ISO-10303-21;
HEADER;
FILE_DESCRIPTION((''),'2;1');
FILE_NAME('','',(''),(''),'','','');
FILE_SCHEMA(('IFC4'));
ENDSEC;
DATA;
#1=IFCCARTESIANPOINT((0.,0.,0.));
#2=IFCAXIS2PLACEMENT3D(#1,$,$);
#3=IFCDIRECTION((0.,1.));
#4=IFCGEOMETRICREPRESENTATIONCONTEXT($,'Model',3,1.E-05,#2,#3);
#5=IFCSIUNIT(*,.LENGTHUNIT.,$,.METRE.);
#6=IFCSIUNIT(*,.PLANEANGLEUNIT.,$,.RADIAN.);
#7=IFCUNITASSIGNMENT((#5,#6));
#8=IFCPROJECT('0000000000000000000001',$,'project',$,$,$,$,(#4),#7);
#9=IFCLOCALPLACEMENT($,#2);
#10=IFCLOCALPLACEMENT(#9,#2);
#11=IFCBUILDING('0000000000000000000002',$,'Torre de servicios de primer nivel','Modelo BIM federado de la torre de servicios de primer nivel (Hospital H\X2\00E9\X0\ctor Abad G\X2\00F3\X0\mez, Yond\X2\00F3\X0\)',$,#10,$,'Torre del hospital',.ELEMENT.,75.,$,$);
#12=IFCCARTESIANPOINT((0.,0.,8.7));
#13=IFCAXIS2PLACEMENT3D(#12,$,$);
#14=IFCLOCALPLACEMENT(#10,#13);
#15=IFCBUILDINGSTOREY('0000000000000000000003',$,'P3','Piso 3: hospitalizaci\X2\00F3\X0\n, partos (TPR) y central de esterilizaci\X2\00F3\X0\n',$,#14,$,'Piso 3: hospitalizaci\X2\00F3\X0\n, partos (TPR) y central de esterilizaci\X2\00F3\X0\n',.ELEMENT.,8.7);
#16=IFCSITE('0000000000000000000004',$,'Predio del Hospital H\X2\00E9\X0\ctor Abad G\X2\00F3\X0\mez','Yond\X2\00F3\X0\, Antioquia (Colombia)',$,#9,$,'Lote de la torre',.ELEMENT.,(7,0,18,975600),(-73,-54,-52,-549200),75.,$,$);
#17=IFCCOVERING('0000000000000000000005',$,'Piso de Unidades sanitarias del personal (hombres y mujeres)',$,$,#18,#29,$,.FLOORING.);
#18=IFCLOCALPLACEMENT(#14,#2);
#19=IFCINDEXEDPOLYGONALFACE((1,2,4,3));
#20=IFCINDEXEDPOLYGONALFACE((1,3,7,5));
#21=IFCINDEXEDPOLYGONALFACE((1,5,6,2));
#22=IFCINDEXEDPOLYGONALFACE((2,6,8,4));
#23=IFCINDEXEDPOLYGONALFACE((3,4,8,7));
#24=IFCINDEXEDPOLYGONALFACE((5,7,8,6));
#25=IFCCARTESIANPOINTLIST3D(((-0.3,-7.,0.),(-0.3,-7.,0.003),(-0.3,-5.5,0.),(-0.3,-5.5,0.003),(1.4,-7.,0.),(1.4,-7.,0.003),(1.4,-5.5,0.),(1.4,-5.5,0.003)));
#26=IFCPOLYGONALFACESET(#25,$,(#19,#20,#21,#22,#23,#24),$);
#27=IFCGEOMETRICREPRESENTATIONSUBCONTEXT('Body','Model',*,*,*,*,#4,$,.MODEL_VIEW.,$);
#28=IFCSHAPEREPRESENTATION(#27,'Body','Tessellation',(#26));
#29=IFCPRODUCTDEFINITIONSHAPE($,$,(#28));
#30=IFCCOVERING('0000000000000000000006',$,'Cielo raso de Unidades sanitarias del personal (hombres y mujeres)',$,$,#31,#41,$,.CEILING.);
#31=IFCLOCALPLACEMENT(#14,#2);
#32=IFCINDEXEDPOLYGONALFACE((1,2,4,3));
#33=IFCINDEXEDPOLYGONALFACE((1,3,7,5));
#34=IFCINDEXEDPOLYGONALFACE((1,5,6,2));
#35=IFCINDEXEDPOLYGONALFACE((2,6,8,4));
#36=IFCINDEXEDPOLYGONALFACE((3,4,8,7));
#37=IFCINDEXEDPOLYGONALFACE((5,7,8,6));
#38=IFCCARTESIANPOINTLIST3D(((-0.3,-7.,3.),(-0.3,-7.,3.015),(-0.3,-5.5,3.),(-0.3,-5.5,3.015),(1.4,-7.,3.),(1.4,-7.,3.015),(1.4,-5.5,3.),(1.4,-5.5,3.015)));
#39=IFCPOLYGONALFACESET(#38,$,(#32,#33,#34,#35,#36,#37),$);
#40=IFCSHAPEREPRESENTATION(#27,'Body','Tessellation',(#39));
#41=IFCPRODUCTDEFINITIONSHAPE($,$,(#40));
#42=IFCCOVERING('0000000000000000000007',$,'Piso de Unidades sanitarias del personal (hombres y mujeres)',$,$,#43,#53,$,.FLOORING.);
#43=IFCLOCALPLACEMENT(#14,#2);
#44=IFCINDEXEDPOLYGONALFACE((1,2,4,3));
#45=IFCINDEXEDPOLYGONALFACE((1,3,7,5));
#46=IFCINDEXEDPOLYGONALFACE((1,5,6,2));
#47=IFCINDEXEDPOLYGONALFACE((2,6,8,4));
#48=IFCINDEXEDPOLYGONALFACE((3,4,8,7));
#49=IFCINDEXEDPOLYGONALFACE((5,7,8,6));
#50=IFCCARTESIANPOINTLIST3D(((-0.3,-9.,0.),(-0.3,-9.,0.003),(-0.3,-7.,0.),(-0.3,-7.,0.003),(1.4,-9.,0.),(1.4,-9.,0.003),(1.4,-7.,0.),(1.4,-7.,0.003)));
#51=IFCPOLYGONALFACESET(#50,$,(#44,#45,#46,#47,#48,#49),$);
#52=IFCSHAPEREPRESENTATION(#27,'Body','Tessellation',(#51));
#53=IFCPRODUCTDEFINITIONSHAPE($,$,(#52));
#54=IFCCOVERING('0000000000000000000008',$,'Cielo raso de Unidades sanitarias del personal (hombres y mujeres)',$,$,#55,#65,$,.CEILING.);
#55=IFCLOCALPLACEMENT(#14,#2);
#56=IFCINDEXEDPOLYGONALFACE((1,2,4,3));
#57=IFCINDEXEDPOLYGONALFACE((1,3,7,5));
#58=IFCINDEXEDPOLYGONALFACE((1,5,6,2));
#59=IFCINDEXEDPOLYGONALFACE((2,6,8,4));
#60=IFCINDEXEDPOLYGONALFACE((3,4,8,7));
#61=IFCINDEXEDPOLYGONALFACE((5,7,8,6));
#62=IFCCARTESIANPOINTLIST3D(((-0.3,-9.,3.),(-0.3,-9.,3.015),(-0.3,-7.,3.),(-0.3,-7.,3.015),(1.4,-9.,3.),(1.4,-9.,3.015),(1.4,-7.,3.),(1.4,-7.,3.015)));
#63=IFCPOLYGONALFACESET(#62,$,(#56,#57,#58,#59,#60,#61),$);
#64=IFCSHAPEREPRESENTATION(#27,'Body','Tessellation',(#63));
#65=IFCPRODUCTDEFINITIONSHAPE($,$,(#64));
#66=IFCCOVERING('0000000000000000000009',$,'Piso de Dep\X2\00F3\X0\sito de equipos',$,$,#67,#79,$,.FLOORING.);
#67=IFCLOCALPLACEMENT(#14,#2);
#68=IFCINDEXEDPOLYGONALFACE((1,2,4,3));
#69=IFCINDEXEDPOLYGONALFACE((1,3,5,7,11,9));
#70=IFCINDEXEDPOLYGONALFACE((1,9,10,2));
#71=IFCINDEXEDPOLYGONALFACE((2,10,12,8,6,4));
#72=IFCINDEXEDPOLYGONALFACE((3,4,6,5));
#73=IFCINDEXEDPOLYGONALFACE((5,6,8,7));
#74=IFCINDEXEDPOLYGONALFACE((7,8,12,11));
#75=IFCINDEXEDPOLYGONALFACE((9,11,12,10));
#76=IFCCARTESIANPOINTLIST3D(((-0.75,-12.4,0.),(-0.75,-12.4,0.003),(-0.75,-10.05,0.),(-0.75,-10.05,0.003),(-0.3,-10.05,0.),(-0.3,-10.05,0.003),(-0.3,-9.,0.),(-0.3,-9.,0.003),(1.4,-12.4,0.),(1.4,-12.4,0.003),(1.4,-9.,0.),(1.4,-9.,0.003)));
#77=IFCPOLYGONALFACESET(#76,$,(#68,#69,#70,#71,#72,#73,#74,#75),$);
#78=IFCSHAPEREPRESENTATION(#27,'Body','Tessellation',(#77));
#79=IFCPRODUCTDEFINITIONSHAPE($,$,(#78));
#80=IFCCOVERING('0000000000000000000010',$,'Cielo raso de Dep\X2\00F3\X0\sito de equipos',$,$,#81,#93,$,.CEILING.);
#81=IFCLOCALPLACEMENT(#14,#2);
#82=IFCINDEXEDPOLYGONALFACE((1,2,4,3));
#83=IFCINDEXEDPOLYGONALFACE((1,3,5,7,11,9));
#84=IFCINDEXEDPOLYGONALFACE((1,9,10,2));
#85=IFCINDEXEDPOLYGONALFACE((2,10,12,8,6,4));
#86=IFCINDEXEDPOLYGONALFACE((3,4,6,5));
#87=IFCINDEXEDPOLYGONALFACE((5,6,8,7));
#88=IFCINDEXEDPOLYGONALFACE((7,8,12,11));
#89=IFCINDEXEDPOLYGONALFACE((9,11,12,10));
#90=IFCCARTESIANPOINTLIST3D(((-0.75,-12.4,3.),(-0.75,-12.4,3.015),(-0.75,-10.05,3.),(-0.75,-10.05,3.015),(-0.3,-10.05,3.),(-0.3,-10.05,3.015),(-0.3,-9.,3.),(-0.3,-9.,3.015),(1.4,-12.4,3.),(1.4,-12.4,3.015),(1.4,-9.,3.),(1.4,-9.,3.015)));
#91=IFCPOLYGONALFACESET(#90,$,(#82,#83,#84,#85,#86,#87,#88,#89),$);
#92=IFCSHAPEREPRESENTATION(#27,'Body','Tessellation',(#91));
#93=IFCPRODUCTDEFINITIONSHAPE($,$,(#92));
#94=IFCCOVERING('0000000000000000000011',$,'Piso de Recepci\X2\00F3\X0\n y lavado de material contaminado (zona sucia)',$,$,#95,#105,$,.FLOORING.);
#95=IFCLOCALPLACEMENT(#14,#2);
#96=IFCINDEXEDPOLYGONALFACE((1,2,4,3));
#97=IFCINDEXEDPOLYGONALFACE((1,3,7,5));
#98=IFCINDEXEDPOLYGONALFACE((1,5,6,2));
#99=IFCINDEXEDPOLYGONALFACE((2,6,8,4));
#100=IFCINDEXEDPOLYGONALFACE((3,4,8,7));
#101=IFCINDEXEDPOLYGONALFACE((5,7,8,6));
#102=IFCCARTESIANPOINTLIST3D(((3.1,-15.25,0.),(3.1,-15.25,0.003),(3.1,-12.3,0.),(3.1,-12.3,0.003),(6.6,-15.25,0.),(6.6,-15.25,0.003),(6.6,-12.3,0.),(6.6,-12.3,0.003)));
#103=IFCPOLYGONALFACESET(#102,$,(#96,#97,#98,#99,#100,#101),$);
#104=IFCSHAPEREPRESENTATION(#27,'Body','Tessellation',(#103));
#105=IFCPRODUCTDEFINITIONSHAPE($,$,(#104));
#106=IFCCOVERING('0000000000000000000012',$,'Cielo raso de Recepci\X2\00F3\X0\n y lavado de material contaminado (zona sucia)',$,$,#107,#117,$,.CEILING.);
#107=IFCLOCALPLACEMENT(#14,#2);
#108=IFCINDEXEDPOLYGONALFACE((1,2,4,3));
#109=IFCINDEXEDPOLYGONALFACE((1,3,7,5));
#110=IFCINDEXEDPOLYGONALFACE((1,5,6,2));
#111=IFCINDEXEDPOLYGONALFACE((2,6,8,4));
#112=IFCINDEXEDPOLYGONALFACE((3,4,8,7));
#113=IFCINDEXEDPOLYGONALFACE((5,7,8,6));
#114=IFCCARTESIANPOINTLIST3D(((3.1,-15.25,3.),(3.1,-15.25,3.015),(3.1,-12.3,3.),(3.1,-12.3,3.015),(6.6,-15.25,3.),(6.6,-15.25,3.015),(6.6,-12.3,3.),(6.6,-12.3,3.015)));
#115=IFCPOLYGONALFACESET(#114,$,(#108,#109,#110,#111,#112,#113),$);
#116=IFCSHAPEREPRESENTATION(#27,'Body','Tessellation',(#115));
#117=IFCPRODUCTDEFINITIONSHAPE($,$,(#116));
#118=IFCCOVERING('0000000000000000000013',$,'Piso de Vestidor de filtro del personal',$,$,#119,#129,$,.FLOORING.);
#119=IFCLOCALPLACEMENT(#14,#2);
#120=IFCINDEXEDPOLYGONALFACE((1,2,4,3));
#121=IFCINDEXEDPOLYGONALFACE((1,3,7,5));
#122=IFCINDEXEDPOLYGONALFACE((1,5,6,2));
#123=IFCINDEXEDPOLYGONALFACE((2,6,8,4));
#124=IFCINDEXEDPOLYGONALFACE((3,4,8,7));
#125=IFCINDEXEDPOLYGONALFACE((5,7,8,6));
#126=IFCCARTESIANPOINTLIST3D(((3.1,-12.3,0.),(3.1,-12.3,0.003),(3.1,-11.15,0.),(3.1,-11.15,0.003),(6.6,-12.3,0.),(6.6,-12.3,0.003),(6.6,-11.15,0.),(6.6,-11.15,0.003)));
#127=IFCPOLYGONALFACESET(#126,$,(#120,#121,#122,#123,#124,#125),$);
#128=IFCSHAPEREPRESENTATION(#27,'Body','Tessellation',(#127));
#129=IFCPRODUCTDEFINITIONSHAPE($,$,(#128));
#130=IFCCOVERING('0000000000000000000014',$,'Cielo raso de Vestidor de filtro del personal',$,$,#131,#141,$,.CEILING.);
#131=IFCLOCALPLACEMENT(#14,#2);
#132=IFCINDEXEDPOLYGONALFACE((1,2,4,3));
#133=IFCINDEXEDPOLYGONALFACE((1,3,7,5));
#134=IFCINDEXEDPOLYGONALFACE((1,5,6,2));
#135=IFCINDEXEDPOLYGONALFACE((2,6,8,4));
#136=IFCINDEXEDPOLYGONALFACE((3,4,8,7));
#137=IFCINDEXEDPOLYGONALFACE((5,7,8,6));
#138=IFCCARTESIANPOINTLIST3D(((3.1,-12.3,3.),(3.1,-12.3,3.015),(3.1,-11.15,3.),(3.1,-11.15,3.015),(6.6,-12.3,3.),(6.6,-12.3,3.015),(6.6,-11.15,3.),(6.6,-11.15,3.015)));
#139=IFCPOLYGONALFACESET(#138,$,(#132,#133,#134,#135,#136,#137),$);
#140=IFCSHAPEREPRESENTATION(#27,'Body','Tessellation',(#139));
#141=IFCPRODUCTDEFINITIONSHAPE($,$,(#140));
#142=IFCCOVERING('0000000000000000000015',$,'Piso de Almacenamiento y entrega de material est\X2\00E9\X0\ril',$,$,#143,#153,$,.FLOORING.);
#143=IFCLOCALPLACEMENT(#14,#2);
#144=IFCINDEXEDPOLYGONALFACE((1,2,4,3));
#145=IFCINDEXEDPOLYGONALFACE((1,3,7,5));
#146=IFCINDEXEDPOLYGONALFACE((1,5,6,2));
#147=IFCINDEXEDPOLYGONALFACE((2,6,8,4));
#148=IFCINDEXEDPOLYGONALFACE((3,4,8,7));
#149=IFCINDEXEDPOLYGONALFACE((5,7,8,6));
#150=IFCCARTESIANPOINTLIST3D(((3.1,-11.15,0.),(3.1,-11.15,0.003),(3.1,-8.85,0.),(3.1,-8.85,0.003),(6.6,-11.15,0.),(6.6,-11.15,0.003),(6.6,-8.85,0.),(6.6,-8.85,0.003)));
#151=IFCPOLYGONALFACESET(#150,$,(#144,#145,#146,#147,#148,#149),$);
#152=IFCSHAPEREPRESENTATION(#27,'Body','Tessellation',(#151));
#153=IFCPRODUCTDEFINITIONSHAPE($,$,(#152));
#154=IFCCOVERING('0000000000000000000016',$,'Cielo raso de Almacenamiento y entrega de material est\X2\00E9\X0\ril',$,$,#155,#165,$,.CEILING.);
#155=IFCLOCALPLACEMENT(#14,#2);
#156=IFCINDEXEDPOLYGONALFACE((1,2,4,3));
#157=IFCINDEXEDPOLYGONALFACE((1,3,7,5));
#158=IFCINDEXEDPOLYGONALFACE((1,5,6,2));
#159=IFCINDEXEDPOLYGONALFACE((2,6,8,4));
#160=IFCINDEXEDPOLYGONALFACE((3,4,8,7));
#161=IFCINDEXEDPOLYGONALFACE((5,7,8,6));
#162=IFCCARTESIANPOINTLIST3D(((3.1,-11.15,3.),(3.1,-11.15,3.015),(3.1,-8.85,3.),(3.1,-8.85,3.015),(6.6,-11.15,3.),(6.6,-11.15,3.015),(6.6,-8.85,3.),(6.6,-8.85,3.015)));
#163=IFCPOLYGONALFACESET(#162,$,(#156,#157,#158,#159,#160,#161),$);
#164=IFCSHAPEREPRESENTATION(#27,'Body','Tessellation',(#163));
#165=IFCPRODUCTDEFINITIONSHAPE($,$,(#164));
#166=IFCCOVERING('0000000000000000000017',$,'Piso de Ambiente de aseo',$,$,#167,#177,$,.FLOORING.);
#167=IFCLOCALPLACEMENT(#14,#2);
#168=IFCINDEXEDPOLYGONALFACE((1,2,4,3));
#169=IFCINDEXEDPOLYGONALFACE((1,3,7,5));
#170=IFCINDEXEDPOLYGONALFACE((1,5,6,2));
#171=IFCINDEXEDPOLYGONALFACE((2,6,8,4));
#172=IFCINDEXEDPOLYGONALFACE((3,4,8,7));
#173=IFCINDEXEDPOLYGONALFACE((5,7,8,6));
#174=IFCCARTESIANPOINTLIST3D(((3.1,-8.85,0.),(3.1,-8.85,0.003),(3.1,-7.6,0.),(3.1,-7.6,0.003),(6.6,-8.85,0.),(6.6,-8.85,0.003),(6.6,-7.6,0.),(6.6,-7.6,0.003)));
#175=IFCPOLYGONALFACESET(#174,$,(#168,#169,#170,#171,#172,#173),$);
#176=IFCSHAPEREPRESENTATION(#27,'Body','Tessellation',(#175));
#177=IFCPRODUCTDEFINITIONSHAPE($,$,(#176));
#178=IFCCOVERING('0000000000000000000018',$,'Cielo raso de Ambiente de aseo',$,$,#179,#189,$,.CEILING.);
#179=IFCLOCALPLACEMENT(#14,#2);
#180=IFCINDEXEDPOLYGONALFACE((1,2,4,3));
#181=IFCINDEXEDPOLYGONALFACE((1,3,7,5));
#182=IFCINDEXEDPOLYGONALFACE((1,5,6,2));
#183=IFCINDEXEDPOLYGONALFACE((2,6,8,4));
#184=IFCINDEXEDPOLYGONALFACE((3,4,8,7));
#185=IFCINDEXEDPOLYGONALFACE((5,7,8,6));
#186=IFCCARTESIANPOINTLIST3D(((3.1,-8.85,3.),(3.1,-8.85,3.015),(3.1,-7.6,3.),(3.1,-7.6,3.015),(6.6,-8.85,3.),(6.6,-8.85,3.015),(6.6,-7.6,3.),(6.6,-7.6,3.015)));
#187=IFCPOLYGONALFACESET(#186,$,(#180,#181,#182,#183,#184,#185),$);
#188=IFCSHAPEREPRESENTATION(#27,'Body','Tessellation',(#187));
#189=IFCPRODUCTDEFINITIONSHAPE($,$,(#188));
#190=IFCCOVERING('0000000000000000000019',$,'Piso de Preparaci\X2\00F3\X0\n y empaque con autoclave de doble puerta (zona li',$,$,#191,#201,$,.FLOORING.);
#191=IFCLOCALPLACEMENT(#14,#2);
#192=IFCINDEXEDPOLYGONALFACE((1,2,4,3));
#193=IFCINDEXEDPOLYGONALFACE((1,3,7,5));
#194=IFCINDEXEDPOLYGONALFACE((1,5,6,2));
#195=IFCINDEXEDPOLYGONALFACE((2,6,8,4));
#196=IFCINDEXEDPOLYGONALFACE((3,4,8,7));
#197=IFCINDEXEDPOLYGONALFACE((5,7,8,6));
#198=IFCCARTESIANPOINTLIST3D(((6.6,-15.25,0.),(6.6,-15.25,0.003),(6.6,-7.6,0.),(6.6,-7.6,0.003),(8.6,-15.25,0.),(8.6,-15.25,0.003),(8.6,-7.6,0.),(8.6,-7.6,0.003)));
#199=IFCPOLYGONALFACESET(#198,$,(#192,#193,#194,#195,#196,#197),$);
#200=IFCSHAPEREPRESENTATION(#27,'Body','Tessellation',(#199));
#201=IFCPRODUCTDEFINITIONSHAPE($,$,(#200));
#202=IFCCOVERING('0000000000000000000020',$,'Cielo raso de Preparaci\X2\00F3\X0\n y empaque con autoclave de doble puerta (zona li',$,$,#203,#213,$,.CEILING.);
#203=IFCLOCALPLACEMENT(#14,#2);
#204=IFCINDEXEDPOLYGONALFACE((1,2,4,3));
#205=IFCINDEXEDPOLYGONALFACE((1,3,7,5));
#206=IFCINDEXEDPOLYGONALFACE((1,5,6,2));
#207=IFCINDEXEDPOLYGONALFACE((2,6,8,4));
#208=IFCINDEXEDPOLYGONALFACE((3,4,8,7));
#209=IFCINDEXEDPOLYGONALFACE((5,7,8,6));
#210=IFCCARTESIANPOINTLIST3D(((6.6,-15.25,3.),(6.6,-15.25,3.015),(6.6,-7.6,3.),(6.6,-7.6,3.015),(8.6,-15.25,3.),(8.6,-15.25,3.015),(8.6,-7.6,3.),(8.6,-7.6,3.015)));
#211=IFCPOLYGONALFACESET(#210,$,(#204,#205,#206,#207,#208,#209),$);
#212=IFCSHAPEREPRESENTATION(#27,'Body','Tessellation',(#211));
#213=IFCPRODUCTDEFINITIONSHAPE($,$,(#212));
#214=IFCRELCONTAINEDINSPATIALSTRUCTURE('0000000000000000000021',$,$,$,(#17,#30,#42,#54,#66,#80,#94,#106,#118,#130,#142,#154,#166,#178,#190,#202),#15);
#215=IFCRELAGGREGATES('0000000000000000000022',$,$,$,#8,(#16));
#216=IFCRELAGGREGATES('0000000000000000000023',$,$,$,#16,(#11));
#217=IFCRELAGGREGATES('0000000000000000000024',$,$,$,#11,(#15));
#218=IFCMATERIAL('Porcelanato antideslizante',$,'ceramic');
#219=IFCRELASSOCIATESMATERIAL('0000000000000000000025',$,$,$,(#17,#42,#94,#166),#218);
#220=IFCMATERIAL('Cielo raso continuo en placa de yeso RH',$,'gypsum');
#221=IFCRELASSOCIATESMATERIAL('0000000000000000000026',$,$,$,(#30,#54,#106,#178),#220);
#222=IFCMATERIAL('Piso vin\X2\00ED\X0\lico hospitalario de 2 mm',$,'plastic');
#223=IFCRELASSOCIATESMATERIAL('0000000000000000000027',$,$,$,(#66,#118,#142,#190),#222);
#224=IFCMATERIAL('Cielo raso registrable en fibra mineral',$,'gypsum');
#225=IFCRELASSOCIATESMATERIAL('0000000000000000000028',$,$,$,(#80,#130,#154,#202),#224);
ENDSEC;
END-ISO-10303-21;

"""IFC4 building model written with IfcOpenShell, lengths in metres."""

from ifc_helpers import new_model, si_unit, direction, frame, origin, place, context, subcontext, project, spatial, indexed_curve, outline, extrude, material, element, save


model = new_model("IFC4")

# Units and contexts
model_context = context("Model", 3, precision=1e-05, world=origin(), true_north=direction((0.0, 1.0)))
body_context = subcontext(model_context, "Body", "Model", "MODEL_VIEW")
ifc_project = project(units=[si_unit("LENGTHUNIT", "METRE"), si_unit("PLANEANGLEUNIT", "RADIAN")], contexts=[model_context])

# Site, building, storey
site_placement = place(None, origin())
site = spatial("IfcSite", under=ifc_project, at=site_placement, Name="Predio del Hospital Héctor Abad Gómez", Description="Yondó, Antioquia (Colombia)", LongName="Lote de la torre", CompositionType="ELEMENT", RefLatitude=(7, 0, 18, 975600), RefLongitude=(-73, -54, -52, -549200), RefElevation=75.0)
building_placement = place(site_placement, origin())
building = spatial("IfcBuilding", under=site, at=building_placement, Name="Torre de servicios de primer nivel", Description="Modelo BIM federado de la torre de servicios de primer nivel (Hospital Héctor Abad Gómez, Yondó)", LongName="Torre del hospital", CompositionType="ELEMENT", ElevationOfRefHeight=75.0)
placement = place(building_placement, frame((0.0, 0.0, 8.7)))
storey = spatial("IfcBuildingStorey", under=building, at=placement, Name="P3", Description="Piso 3: hospitalización, partos (TPR) y central de esterilización", LongName="Piso 3: hospitalización, partos (TPR) y central de esterilización", CompositionType="ELEMENT", Elevation=8.7)

# Coverings
ifc_material_1 = material(Name="Porcelanato antideslizante", Category="ceramic")
element("IfcCovering", 1, at=placement, inside=storey, material=ifc_material_1, Name="Piso de Unidades sanitarias del personal (hombres y mujeres)", PredefinedType="FLOORING", context=body_context, shape_type="SweptSolid", body=[
    extrude(outline(indexed_curve([(-0.3, -7.0), (1.4, -7.0), (1.4, -5.5), (-0.3, -5.5), (-0.3, -7.0)], self_intersect=False)), origin(), (0.0, 0.0, 1.0), 0.003),
])
ifc_material_2 = material(Name="Cielo raso continuo en placa de yeso RH", Category="gypsum")
element("IfcCovering", 2, at=placement, inside=storey, material=ifc_material_2, Name="Cielo raso de Unidades sanitarias del personal (hombres y mujeres)", PredefinedType="CEILING", context=body_context, shape_type="SweptSolid", body=[
    extrude(outline(indexed_curve([(-0.3, -7.0), (1.4, -7.0), (1.4, -5.5), (-0.3, -5.5), (-0.3, -7.0)], self_intersect=False)), frame((0.0, 0.0, 3.0)), (0.0, 0.0, 1.0), 0.015),
])
element("IfcCovering", 3, at=placement, inside=storey, material=ifc_material_1, Name="Piso de Unidades sanitarias del personal (hombres y mujeres)", PredefinedType="FLOORING", context=body_context, shape_type="SweptSolid", body=[
    extrude(outline(indexed_curve([(-0.3, -9.0), (1.4, -9.0), (1.4, -7.0), (-0.3, -7.0), (-0.3, -9.0)], self_intersect=False)), origin(), (0.0, 0.0, 1.0), 0.003),
])
element("IfcCovering", 4, at=placement, inside=storey, material=ifc_material_2, Name="Cielo raso de Unidades sanitarias del personal (hombres y mujeres)", PredefinedType="CEILING", context=body_context, shape_type="SweptSolid", body=[
    extrude(outline(indexed_curve([(-0.3, -9.0), (1.4, -9.0), (1.4, -7.0), (-0.3, -7.0), (-0.3, -9.0)], self_intersect=False)), frame((0.0, 0.0, 3.0)), (0.0, 0.0, 1.0), 0.015),
])
ifc_material_3 = material(Name="Piso vinílico hospitalario de 2 mm", Category="plastic")
element("IfcCovering", 5, at=placement, inside=storey, material=ifc_material_3, Name="Piso de Depósito de equipos", PredefinedType="FLOORING", context=body_context, shape_type="SweptSolid", body=[
    extrude(outline(indexed_curve([(-0.75, -12.4), (1.4, -12.4), (1.4, -9.0), (-0.3, -9.0), (-0.3, -10.05), (-0.75, -10.05), (-0.75, -12.4)], self_intersect=False)), origin(), (0.0, 0.0, 1.0), 0.003),
])
ifc_material_4 = material(Name="Cielo raso registrable en fibra mineral", Category="gypsum")
element("IfcCovering", 6, at=placement, inside=storey, material=ifc_material_4, Name="Cielo raso de Depósito de equipos", PredefinedType="CEILING", context=body_context, shape_type="SweptSolid", body=[
    extrude(outline(indexed_curve([(-0.75, -12.4), (1.4, -12.4), (1.4, -9.0), (-0.3, -9.0), (-0.3, -10.05), (-0.75, -10.05), (-0.75, -12.4)], self_intersect=False)), frame((0.0, 0.0, 3.0)), (0.0, 0.0, 1.0), 0.015),
])
element("IfcCovering", 7, at=placement, inside=storey, material=ifc_material_1, Name="Piso de Recepción y lavado de material contaminado (zona sucia)", PredefinedType="FLOORING", context=body_context, shape_type="SweptSolid", body=[
    extrude(outline(indexed_curve([(3.1, -15.25), (6.6, -15.25), (6.6, -12.3), (3.1, -12.3), (3.1, -15.25)], self_intersect=False)), origin(), (0.0, 0.0, 1.0), 0.003),
])
element("IfcCovering", 8, at=placement, inside=storey, material=ifc_material_2, Name="Cielo raso de Recepción y lavado de material contaminado (zona sucia)", PredefinedType="CEILING", context=body_context, shape_type="SweptSolid", body=[
    extrude(outline(indexed_curve([(3.1, -15.25), (6.6, -15.25), (6.6, -12.3), (3.1, -12.3), (3.1, -15.25)], self_intersect=False)), frame((0.0, 0.0, 3.0)), (0.0, 0.0, 1.0), 0.015),
])
element("IfcCovering", 9, at=placement, inside=storey, material=ifc_material_3, Name="Piso de Vestidor de filtro del personal", PredefinedType="FLOORING", context=body_context, shape_type="SweptSolid", body=[
    extrude(outline(indexed_curve([(3.1, -12.3), (6.6, -12.3), (6.6, -11.15), (3.1, -11.15), (3.1, -12.3)], self_intersect=False)), origin(), (0.0, 0.0, 1.0), 0.003),
])
element("IfcCovering", 10, at=placement, inside=storey, material=ifc_material_4, Name="Cielo raso de Vestidor de filtro del personal", PredefinedType="CEILING", context=body_context, shape_type="SweptSolid", body=[
    extrude(outline(indexed_curve([(3.1, -12.3), (6.6, -12.3), (6.6, -11.15), (3.1, -11.15), (3.1, -12.3)], self_intersect=False)), frame((0.0, 0.0, 3.0)), (0.0, 0.0, 1.0), 0.015),
])
element("IfcCovering", 11, at=placement, inside=storey, material=ifc_material_3, Name="Piso de Almacenamiento y entrega de material estéril", PredefinedType="FLOORING", context=body_context, shape_type="SweptSolid", body=[
    extrude(outline(indexed_curve([(3.1, -11.15), (6.6, -11.15), (6.6, -8.85), (3.1, -8.85), (3.1, -11.15)], self_intersect=False)), origin(), (0.0, 0.0, 1.0), 0.003),
])
element("IfcCovering", 12, at=placement, inside=storey, material=ifc_material_4, Name="Cielo raso de Almacenamiento y entrega de material estéril", PredefinedType="CEILING", context=body_context, shape_type="SweptSolid", body=[
    extrude(outline(indexed_curve([(3.1, -11.15), (6.6, -11.15), (6.6, -8.85), (3.1, -8.85), (3.1, -11.15)], self_intersect=False)), frame((0.0, 0.0, 3.0)), (0.0, 0.0, 1.0), 0.015),
])
element("IfcCovering", 13, at=placement, inside=storey, material=ifc_material_1, Name="Piso de Ambiente de aseo", PredefinedType="FLOORING", context=body_context, shape_type="SweptSolid", body=[
    extrude(outline(indexed_curve([(3.1, -8.85), (6.6, -8.85), (6.6, -7.6), (3.1, -7.6), (3.1, -8.85)], self_intersect=False)), origin(), (0.0, 0.0, 1.0), 0.003),
])
element("IfcCovering", 14, at=placement, inside=storey, material=ifc_material_2, Name="Cielo raso de Ambiente de aseo", PredefinedType="CEILING", context=body_context, shape_type="SweptSolid", body=[
    extrude(outline(indexed_curve([(3.1, -8.85), (6.6, -8.85), (6.6, -7.6), (3.1, -7.6), (3.1, -8.85)], self_intersect=False)), frame((0.0, 0.0, 3.0)), (0.0, 0.0, 1.0), 0.015),
])
element("IfcCovering", 15, at=placement, inside=storey, material=ifc_material_3, Name="Piso de Preparación y empaque con autoclave de doble puerta (zona li", PredefinedType="FLOORING", context=body_context, shape_type="SweptSolid", body=[
    extrude(outline(indexed_curve([(6.6, -15.25), (8.6, -15.25), (8.6, -7.6), (6.6, -7.6), (6.6, -15.25)], self_intersect=False)), origin(), (0.0, 0.0, 1.0), 0.003),
])
element("IfcCovering", 16, at=placement, inside=storey, material=ifc_material_4, Name="Cielo raso de Preparación y empaque con autoclave de doble puerta (zona li", PredefinedType="CEILING", context=body_context, shape_type="SweptSolid", body=[
    extrude(outline(indexed_curve([(6.6, -15.25), (8.6, -15.25), (8.6, -7.6), (6.6, -7.6), (6.6, -15.25)], self_intersect=False)), frame((0.0, 0.0, 3.0)), (0.0, 0.0, 1.0), 0.015),
])

save(model, "model.ifc")
